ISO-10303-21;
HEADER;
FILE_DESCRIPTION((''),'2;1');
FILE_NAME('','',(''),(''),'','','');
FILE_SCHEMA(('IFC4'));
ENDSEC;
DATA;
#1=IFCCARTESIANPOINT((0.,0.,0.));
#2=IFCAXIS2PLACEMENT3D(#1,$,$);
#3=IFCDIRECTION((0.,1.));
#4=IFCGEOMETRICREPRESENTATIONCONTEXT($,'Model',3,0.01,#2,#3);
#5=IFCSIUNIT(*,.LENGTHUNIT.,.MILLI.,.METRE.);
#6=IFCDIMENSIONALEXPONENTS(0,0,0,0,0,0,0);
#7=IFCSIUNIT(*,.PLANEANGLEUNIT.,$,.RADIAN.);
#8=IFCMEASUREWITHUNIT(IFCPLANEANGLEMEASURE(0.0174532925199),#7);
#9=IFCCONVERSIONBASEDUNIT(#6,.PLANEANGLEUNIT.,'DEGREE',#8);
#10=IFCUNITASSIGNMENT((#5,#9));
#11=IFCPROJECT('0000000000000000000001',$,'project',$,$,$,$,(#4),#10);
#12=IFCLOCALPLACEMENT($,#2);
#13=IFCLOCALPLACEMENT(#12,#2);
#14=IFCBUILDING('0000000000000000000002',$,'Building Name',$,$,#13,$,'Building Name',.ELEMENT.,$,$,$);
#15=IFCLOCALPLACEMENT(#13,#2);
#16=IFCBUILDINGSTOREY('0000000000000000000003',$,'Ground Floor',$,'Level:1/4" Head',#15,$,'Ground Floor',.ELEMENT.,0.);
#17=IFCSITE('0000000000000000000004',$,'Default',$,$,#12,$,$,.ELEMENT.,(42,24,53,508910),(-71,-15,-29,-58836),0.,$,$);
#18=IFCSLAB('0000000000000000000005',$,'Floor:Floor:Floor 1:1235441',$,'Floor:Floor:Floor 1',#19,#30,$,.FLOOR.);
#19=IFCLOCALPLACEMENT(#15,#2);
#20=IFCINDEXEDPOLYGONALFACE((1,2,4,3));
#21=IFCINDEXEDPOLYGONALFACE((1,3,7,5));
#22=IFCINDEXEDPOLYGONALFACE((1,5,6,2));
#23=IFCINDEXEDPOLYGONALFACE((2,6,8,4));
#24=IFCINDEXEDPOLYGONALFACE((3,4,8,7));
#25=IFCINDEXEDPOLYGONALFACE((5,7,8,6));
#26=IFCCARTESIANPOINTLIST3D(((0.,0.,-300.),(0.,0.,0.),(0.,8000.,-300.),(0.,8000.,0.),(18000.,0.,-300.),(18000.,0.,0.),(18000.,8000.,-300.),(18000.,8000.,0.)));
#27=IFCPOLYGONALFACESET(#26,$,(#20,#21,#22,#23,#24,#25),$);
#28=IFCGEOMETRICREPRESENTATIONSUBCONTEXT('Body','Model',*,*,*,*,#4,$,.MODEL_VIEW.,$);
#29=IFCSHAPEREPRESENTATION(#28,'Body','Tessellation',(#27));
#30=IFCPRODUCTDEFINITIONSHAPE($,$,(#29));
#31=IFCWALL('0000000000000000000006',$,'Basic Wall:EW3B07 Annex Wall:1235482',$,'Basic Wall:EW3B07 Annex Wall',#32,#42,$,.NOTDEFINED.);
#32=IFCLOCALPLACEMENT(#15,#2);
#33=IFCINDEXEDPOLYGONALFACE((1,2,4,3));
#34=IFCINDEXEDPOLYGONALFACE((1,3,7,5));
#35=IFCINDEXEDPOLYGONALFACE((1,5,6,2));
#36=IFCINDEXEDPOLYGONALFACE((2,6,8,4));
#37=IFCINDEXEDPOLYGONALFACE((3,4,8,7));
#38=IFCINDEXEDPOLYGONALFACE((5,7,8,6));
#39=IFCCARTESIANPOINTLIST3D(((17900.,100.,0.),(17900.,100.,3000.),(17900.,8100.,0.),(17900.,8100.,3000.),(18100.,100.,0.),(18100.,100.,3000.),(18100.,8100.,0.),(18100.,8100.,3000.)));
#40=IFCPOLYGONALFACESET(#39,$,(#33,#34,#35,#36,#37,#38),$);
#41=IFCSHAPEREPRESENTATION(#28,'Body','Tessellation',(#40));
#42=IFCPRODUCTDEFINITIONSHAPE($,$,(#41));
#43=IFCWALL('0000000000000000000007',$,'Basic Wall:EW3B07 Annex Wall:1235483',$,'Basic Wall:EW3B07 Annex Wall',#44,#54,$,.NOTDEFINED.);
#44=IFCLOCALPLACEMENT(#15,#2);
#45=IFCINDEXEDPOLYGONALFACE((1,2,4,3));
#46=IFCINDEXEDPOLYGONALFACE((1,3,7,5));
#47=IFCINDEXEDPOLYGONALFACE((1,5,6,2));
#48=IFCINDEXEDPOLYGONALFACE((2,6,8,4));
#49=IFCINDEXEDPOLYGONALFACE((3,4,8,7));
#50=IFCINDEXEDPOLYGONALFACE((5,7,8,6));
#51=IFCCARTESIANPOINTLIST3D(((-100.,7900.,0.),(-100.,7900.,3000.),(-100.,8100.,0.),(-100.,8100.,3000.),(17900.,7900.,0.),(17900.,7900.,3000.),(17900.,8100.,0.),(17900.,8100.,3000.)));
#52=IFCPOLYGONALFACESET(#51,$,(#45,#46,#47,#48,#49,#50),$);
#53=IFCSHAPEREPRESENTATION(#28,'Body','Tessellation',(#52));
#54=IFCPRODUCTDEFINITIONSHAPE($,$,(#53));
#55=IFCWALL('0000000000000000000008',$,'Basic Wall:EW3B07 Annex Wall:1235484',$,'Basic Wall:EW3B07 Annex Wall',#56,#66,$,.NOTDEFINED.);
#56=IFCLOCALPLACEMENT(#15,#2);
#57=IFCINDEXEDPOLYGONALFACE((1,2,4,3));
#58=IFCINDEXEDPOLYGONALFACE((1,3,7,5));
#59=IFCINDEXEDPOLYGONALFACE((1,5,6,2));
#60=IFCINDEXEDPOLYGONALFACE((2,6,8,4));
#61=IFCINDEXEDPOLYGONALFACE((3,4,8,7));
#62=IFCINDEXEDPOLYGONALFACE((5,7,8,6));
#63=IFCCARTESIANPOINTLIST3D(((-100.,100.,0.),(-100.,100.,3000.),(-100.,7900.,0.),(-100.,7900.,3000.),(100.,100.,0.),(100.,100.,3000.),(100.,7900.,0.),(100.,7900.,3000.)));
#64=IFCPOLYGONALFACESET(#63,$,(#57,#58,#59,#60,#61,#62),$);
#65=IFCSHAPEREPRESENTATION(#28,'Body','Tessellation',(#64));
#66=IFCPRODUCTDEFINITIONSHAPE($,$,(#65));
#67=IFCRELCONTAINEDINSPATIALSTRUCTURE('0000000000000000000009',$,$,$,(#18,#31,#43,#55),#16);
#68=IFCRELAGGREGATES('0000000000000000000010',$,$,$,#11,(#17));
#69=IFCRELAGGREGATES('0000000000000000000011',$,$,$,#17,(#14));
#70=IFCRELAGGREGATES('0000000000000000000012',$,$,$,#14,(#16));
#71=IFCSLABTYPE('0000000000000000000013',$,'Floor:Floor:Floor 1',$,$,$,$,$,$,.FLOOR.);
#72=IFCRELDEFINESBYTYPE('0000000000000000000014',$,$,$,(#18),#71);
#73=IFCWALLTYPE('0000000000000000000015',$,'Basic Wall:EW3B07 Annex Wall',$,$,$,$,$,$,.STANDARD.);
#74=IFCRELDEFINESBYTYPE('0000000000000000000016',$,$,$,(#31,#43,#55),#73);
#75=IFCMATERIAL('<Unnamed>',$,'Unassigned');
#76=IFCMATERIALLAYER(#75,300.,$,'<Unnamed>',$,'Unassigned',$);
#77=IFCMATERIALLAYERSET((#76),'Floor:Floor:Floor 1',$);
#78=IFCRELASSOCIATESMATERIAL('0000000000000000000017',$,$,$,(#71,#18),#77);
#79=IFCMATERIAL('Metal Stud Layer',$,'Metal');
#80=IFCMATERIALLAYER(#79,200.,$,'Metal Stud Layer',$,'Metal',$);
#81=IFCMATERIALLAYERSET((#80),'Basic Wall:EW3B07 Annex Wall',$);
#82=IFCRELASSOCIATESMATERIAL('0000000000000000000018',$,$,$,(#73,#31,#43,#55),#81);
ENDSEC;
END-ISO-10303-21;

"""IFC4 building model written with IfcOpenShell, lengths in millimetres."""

from ifc_helpers import new_model, entity, si_unit, converted_unit, direction, frame, frame_2d, origin, origin_2d_with_axis, place, context, subcontext, project, spatial, rectangle, extrude, material, layer, layer_set, layer_usage, type_object, element, save


model = new_model("IFC4")

# Units and contexts
model_context = context("Model", 3, precision=0.01, world=origin(), true_north=direction((0.0, 1.0)))
body_context = subcontext(model_context, "Body", "Model", "MODEL_VIEW")
ifc_project = project(units=[si_unit("LENGTHUNIT", "METRE", prefix="MILLI"), converted_unit("PLANEANGLEUNIT", "DEGREE", entity("IfcPlaneAngleMeasure", 0.0174532925199), si_unit("PLANEANGLEUNIT", "RADIAN"), dimensions=[0, 0, 0, 0, 0, 0, 0])], contexts=[model_context])

# Site, building, storey
site_placement = place(None, origin())
site = spatial("IfcSite", under=ifc_project, at=site_placement, Name="Default", CompositionType="ELEMENT", RefLatitude=(42, 24, 53, 508910), RefLongitude=(-71, -15, -29, -58836), RefElevation=0.0)
building_placement = place(site_placement, origin())
building = spatial("IfcBuilding", under=site, at=building_placement, Name="Building Name", LongName="Building Name", CompositionType="ELEMENT")
storey_placement = place(building_placement, origin())
storey = spatial("IfcBuildingStorey", under=building, at=storey_placement, Name="Ground Floor", ObjectType="Level:1/4\" Head", LongName="Ground Floor", CompositionType="ELEMENT", Elevation=0.0)

# Slab
ifc_material_1 = material(Name="<Unnamed>", Category="Unassigned")
ifc_layer_1 = layer(ifc_material_1, 300.0, Name="<Unnamed>", Category="Unassigned")
ifc_layer_set_1 = layer_set([ifc_layer_1], Name="Floor:Floor:Floor 1")
ifc_layer_usage_1 = layer_usage(ifc_layer_set_1, "AXIS3", "POSITIVE", 0.0)
slab_type = type_object("IfcSlabType", Name="Floor:Floor:Floor 1", PredefinedType="FLOOR", material=ifc_layer_set_1)
slab_placement = place(storey_placement, origin())
element("IfcSlab", 1, at=slab_placement, inside=storey, type_object=slab_type, material=ifc_layer_usage_1, Name="Floor:Floor:Floor 1:1235441", ObjectType="Floor:Floor:Floor 1", PredefinedType="FLOOR", context=body_context, shape_type="SweptSolid", body=[
    extrude(rectangle(XDim=8000.0, YDim=18000.0, at=origin_2d_with_axis()), frame((9000.0, 4000.0, 0.0), z_axis=(0.0, 0.0, -1.0), x_axis=(0.0, 1.0, 0.0)), (0.0, 0.0, 1.0), 300.0),
])

# Shared definitions
ifc_material_2 = material(Name="Metal Stud Layer", Category="Metal")
ifc_layer_2 = layer(ifc_material_2, 200.0, Name="Metal Stud Layer", Category="Metal")
ifc_layer_set_2 = layer_set([ifc_layer_2], Name="Basic Wall:EW3B07 Annex Wall")
wall_type = type_object("IfcWallType", Name="Basic Wall:EW3B07 Annex Wall", PredefinedType="STANDARD", material=ifc_layer_set_2)

# Walls
ifc_layer_usage_2 = layer_usage(ifc_layer_set_2, "AXIS2", "NEGATIVE", 100.0)
wall_1_placement = place(storey_placement, frame((18000.0, 100.0, 0.0), z_axis=(0.0, 0.0, 1.0), x_axis=(0.0, 1.0, 0.0)))
element("IfcWall", 2, at=wall_1_placement, inside=storey, type_object=wall_type, material=ifc_layer_usage_2, Name="Basic Wall:EW3B07 Annex Wall:1235482", ObjectType="Basic Wall:EW3B07 Annex Wall", PredefinedType="NOTDEFINED", context=body_context, shape_type="SweptSolid", body=[
    extrude(rectangle(XDim=8000.0, YDim=200.0, at=frame_2d((4000.0, 0.0), x_axis=(-1.0, 0.0))), origin(), (0.0, 0.0, 1.0), 3000.0),
])
ifc_layer_usage_3 = layer_usage(ifc_layer_set_2, "AXIS2", "NEGATIVE", 100.0)
wall_2_placement = place(storey_placement, frame((17900.0, 8000.0, 0.0), z_axis=(0.0, 0.0, 1.0), x_axis=(-1.0, 0.0, 0.0)))
element("IfcWall", 3, at=wall_2_placement, inside=storey, type_object=wall_type, material=ifc_layer_usage_3, Name="Basic Wall:EW3B07 Annex Wall:1235483", ObjectType="Basic Wall:EW3B07 Annex Wall", PredefinedType="NOTDEFINED", context=body_context, shape_type="SweptSolid", body=[
    extrude(rectangle(XDim=18000.0, YDim=200.0, at=frame_2d((9000.0, 0.0), x_axis=(-1.0, 0.0))), origin(), (0.0, 0.0, 1.0), 3000.0),
])
ifc_layer_usage_4 = layer_usage(ifc_layer_set_2, "AXIS2", "NEGATIVE", 100.0)
wall_3_placement = place(storey_placement, frame((0.0, 7900.0, 0.0), z_axis=(0.0, 0.0, 1.0), x_axis=(0.0, -1.0, 0.0)))
element("IfcWall", 4, at=wall_3_placement, inside=storey, type_object=wall_type, material=ifc_layer_usage_4, Name="Basic Wall:EW3B07 Annex Wall:1235484", ObjectType="Basic Wall:EW3B07 Annex Wall", PredefinedType="NOTDEFINED", context=body_context, shape_type="SweptSolid", body=[
    extrude(rectangle(XDim=7800.0, YDim=200.0, at=frame_2d((3900.0, 0.0), x_axis=(-1.0, 0.0))), origin(), (0.0, 0.0, 1.0), 3000.0),
])

save(model, "model.ifc")
